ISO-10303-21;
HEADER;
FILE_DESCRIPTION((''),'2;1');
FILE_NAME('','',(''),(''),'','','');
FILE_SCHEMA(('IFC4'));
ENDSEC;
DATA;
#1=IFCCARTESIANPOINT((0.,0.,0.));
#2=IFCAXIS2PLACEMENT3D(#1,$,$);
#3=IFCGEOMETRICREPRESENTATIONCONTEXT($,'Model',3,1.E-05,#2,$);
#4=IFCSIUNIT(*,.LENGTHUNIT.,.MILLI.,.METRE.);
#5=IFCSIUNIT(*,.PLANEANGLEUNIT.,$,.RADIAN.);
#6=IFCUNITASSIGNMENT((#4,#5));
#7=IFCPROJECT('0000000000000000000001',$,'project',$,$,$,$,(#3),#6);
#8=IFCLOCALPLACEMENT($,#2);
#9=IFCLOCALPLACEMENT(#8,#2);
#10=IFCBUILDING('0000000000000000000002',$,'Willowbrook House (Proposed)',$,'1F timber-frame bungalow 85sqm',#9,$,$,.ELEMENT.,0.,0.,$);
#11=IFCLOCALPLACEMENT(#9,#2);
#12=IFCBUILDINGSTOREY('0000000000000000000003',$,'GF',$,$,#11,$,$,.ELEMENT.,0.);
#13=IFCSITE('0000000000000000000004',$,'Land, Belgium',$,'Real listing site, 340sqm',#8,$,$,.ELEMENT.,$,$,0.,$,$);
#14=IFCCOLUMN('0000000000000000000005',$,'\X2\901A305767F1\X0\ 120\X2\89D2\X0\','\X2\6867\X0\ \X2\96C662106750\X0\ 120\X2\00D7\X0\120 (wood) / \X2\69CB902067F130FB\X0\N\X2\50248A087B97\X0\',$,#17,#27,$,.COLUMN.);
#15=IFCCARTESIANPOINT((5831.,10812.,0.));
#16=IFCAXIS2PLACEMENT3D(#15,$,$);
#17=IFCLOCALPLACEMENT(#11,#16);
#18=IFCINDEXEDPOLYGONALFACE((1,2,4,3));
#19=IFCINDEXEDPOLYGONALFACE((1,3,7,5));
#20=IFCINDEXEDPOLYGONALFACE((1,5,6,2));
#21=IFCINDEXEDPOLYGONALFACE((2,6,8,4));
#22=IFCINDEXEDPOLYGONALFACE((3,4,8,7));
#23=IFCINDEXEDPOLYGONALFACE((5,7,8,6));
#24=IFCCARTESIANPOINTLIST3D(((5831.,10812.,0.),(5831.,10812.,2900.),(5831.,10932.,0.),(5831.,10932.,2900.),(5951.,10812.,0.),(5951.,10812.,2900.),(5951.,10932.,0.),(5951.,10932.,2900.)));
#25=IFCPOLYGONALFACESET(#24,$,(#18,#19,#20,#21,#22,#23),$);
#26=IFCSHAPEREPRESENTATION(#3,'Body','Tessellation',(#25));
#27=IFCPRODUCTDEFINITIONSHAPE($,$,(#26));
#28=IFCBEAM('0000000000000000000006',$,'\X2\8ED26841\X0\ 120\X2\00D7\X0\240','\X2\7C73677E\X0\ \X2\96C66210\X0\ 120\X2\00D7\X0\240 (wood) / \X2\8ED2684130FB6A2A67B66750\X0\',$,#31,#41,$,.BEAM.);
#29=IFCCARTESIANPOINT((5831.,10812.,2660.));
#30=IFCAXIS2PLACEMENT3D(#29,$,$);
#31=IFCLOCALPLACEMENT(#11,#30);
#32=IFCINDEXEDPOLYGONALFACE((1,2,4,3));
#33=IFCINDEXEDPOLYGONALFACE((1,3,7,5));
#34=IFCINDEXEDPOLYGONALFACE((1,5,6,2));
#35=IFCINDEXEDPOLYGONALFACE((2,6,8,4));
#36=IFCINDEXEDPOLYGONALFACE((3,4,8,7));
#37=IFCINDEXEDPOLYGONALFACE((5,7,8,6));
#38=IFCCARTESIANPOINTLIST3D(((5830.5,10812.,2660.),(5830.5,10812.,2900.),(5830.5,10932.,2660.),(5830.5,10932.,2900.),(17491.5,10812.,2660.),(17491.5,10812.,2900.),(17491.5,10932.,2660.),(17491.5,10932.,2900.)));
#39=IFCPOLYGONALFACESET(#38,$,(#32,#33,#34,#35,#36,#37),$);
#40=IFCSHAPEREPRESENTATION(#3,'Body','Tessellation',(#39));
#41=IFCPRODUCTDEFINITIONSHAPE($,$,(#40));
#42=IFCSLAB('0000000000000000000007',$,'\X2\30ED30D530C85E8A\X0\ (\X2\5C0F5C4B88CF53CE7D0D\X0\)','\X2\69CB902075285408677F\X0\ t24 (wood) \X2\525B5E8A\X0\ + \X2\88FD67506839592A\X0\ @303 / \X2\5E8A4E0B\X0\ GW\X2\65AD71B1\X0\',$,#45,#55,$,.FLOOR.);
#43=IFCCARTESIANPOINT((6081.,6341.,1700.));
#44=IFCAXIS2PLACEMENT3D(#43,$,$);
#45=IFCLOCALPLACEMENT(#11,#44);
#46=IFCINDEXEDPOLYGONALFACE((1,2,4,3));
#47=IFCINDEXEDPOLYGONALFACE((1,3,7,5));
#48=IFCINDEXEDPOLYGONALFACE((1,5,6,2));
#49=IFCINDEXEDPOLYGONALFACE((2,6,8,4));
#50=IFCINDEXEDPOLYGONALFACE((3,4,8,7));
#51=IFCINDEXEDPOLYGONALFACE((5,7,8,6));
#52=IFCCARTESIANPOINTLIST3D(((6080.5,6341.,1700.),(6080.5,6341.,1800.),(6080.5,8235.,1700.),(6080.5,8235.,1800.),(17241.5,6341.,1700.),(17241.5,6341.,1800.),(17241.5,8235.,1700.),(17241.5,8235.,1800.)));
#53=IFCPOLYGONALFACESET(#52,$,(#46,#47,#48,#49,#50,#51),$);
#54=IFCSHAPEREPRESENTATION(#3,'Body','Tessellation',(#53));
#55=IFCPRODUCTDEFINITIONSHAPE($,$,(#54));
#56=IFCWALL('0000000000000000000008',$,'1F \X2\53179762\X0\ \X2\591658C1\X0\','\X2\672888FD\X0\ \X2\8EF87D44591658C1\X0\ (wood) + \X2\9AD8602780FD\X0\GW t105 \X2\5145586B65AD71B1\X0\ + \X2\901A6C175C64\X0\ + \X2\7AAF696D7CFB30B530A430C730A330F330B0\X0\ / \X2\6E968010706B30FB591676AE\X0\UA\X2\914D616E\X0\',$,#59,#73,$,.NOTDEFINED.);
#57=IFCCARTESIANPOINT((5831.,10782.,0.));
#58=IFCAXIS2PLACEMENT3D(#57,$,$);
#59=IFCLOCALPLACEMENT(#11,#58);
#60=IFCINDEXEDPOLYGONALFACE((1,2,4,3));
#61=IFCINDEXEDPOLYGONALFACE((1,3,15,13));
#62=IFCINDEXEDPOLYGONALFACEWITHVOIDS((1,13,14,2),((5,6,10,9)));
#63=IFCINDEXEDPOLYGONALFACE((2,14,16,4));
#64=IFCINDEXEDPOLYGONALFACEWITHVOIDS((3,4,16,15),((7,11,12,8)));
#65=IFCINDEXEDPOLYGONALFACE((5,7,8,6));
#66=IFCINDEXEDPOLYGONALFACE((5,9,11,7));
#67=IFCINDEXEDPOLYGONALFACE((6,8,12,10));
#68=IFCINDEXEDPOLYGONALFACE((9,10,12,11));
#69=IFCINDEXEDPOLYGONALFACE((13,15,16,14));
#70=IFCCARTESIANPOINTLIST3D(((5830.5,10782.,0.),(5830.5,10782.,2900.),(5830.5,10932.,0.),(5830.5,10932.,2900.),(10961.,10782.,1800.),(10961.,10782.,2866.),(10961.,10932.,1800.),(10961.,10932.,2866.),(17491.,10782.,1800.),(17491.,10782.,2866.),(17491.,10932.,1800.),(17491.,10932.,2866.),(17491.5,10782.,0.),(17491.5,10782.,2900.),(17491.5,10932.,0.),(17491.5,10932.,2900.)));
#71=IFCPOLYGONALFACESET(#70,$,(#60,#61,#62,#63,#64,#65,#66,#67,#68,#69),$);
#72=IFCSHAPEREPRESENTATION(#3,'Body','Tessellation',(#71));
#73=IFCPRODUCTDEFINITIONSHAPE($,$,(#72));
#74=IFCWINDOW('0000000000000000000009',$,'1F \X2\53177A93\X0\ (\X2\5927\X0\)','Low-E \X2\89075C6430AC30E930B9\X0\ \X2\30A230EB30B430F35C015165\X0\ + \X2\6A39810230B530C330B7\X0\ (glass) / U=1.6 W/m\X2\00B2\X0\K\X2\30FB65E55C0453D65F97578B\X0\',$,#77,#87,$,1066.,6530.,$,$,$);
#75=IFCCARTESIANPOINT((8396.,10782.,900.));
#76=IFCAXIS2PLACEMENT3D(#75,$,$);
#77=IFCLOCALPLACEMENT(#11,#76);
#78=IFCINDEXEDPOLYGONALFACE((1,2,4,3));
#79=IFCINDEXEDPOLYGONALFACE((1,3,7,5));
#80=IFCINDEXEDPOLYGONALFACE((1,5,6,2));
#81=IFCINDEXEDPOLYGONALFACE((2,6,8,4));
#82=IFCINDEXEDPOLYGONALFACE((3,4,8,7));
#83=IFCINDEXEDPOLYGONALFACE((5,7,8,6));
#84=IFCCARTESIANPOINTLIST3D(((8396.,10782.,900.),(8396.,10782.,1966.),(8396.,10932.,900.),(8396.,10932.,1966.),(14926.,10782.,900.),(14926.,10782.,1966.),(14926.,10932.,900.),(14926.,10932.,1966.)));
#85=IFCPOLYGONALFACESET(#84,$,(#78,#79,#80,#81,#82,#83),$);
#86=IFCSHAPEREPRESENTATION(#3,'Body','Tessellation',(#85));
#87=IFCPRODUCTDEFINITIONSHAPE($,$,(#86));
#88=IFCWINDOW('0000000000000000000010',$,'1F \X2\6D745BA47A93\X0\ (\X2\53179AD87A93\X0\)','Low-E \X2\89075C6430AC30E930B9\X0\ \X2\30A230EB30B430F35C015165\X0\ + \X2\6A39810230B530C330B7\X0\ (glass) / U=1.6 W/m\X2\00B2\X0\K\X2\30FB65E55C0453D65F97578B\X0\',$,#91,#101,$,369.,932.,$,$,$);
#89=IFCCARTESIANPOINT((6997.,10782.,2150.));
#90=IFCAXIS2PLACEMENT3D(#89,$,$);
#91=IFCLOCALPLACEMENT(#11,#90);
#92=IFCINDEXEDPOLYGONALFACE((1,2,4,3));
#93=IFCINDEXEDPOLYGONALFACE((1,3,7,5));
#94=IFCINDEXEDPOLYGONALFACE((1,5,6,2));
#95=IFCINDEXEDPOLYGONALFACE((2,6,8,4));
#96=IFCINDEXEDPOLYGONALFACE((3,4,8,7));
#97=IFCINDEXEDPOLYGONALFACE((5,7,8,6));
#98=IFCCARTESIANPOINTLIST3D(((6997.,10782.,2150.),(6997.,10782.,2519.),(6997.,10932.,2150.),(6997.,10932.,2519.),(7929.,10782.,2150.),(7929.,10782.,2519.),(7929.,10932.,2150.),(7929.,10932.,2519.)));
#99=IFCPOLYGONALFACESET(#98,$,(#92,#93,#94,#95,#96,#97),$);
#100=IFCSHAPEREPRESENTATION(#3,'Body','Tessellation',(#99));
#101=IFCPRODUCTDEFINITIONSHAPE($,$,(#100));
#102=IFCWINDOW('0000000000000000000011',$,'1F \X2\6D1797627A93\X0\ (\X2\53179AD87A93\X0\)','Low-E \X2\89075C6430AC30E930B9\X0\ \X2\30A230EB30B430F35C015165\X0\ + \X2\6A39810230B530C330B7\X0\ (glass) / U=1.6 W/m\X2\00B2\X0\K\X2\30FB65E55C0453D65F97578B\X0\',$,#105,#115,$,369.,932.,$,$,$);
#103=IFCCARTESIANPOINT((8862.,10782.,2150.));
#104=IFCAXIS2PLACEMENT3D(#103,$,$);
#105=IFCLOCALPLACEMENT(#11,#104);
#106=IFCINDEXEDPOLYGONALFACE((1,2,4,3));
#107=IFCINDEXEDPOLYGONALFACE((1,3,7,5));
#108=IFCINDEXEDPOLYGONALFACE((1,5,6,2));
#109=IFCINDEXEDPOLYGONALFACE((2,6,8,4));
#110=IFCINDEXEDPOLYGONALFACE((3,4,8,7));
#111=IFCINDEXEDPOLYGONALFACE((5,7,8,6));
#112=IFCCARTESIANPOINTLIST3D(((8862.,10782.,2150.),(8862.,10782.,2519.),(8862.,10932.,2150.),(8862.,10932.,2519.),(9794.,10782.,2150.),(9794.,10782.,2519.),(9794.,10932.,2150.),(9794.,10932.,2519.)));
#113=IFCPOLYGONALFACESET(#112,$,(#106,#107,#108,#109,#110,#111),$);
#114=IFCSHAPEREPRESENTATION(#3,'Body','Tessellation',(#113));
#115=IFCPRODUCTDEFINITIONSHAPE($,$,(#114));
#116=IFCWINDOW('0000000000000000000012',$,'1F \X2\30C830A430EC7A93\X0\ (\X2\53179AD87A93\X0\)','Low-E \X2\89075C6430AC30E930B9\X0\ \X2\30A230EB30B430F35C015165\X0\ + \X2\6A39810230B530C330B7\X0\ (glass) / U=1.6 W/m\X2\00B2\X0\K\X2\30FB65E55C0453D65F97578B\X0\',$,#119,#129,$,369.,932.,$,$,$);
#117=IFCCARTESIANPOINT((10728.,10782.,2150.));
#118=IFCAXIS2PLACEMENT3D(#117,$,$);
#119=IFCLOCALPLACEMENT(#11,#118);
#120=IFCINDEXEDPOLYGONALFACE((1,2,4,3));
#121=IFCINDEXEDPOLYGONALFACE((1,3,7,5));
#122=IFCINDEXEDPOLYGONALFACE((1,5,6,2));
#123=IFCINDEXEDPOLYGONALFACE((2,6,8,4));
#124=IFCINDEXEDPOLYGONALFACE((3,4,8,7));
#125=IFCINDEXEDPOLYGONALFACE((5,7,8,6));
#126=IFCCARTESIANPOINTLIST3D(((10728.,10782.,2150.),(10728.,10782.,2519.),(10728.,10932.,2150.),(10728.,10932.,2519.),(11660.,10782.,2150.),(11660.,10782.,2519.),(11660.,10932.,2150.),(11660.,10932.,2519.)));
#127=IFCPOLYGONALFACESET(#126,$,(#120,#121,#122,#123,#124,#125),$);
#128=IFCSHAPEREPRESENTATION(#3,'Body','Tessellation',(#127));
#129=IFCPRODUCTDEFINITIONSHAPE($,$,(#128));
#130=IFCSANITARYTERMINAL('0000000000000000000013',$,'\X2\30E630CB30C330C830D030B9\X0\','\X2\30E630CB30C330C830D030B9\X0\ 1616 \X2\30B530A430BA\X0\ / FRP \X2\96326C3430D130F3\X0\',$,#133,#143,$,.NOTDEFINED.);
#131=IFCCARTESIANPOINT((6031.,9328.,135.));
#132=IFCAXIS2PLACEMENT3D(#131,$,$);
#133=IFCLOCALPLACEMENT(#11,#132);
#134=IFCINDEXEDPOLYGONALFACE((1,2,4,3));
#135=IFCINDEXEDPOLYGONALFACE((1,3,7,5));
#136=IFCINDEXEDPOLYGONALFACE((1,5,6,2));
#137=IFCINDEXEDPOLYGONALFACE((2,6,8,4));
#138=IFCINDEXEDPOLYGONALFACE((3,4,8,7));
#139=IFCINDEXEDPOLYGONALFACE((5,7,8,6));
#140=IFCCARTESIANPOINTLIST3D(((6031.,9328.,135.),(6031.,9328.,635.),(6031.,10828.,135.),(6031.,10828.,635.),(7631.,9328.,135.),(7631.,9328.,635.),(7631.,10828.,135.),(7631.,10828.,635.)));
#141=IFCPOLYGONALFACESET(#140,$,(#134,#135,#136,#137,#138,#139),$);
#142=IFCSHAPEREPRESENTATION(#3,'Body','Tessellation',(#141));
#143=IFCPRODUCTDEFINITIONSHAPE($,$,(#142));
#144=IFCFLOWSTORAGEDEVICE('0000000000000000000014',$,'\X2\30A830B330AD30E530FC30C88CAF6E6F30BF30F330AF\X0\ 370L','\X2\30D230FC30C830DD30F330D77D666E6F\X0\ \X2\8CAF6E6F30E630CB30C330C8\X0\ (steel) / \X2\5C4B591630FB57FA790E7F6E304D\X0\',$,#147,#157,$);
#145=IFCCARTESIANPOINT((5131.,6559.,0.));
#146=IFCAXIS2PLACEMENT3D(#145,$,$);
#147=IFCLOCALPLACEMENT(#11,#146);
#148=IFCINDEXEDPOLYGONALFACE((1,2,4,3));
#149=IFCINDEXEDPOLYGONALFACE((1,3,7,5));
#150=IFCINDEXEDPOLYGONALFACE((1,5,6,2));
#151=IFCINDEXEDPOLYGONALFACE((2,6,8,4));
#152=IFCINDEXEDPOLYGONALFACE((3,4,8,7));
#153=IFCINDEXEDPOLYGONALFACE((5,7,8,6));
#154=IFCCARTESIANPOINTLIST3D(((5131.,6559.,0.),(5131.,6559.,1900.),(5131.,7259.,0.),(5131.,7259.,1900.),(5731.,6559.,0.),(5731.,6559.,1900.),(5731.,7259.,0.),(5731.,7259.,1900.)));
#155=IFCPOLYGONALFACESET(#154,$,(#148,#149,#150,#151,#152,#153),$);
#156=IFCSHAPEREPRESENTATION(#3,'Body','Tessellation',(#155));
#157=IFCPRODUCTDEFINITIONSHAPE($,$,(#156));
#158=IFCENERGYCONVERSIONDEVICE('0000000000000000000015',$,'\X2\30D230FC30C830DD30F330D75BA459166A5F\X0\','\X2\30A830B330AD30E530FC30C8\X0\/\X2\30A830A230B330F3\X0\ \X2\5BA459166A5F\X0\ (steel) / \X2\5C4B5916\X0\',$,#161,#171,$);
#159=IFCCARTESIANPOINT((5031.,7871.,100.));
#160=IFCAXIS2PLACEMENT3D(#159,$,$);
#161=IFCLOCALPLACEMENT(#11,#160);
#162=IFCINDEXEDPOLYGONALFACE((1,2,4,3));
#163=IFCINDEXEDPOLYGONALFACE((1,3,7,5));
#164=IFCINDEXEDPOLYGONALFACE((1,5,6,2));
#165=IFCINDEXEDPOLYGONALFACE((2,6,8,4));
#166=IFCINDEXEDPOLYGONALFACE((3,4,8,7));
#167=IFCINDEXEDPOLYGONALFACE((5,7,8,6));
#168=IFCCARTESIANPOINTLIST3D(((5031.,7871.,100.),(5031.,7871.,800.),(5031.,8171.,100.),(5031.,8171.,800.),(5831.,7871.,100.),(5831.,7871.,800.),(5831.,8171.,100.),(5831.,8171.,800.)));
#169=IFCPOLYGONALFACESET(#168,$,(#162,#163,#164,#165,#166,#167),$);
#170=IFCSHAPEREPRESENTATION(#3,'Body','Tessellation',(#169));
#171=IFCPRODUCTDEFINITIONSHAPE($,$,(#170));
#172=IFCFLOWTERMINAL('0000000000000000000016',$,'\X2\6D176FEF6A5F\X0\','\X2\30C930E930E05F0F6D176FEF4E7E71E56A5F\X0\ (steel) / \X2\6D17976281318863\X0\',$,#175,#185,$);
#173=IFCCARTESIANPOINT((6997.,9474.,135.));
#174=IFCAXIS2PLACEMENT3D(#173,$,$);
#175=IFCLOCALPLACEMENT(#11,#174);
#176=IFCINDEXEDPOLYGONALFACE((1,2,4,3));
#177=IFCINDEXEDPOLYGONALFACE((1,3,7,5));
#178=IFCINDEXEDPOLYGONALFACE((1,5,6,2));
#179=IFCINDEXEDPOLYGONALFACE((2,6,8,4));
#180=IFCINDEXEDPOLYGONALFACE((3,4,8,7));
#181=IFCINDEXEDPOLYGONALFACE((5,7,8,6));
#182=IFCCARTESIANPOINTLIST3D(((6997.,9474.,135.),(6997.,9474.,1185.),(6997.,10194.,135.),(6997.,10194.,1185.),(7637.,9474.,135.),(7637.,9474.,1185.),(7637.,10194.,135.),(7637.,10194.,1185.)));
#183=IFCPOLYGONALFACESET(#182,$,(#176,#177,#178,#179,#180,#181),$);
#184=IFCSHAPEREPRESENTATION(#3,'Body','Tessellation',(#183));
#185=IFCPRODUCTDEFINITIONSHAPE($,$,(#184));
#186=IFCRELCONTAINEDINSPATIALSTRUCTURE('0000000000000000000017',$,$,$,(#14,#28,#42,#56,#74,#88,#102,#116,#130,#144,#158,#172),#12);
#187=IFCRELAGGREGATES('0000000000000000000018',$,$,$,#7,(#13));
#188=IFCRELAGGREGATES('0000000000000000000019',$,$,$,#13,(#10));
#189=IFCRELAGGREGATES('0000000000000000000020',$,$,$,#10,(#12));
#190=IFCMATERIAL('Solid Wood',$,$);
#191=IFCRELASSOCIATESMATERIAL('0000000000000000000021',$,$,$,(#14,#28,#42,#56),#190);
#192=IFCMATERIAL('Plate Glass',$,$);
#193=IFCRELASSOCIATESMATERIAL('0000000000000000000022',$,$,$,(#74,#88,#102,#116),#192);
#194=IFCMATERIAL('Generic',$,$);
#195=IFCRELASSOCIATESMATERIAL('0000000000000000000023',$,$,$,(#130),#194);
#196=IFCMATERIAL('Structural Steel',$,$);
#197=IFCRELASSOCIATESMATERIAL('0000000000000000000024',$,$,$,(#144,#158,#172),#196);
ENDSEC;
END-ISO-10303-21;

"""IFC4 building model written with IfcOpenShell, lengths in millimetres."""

from ifc_helpers import new_model, si_unit, frame, frame_2d, origin, place, context, project, spatial, rectangle, extrude, material, element, fill, save


model = new_model("IFC4")

# Units and contexts
model_context = context("Model", 3, precision=1e-05, world=origin())
ifc_project = project(units=[si_unit("LENGTHUNIT", "METRE", prefix="MILLI"), si_unit("PLANEANGLEUNIT", "RADIAN")], contexts=[model_context])

# Site, building, storey
site_placement = place(None, origin())
site = spatial("IfcSite", under=ifc_project, at=site_placement, Name="Land, Belgium", ObjectType="Real listing site, 340sqm", CompositionType="ELEMENT", RefElevation=0.0)
building_placement = place(site_placement, origin())
building = spatial("IfcBuilding", under=site, at=building_placement, Name="Willowbrook House (Proposed)", ObjectType="1F timber-frame bungalow 85sqm", CompositionType="ELEMENT", ElevationOfRefHeight=0.0, ElevationOfTerrain=0.0)
storey_placement = place(building_placement, origin())
storey = spatial("IfcBuildingStorey", under=building, at=storey_placement, Name="GF", CompositionType="ELEMENT", Elevation=0.0)

# Column
ifc_material_1 = material(Name="Solid Wood")
column_1_placement = place(storey_placement, frame((5831.0, 10812.0, 0.0)))
element("IfcColumn", 1, at=column_1_placement, inside=storey, material=ifc_material_1, Name="通し柱 120角", Description="桧 集成材 120×120 (wood) / 構造柱・N値計算", PredefinedType="COLUMN", context=model_context, shape_type="SweptSolid", body=[
    extrude(rectangle(XDim=120.0, YDim=120.0, at=frame_2d((60.0, 60.0))), frame((5831.0, 10812.0, 0.0)), (0.0, 0.0, 1.0), 2900.0),
])

# Beam
beam_1_placement = place(storey_placement, frame((5831.0, 10812.0, 2660.0)))
element("IfcBeam", 2, at=beam_1_placement, inside=storey, material=ifc_material_1, Name="軒桁 120×240", Description="米松 集成 120×240 (wood) / 軒桁・横架材", PredefinedType="BEAM", context=model_context, shape_type="SweptSolid", body=[
    extrude(rectangle(XDim=11661.0, YDim=120.0, at=frame_2d((5830.0, 60.0))), frame((5831.0, 10812.0, 2660.0)), (0.0, 0.0, 1.0), 240.0),
])

# Slab
slab_placement = place(storey_placement, frame((6081.0, 6341.0, 1700.0)))
element("IfcSlab", 3, at=slab_placement, inside=storey, material=ifc_material_1, Name="ロフト床 (小屋裏収納)", Description="構造用合板 t24 (wood) 剛床 + 製材根太 @303 / 床下 GW断熱", PredefinedType="FLOOR", context=model_context, shape_type="SweptSolid", body=[
    extrude(rectangle(XDim=11161.0, YDim=1894.0, at=frame_2d((5580.0, 947.0))), frame((6081.0, 6341.0, 1700.0)), (0.0, 0.0, 1.0), 100.0),
])

# Wall, openings, windows
wall_1_placement = place(storey_placement, frame((5831.0, 10782.0, 0.0)))
wall_1 = element("IfcWall", 4, at=wall_1_placement, inside=storey, material=ifc_material_1, Name="1F 北面 外壁", Description="木製 軸組外壁 (wood) + 高性能GW t105 充填断熱 + 通気層 + 窯業系サイディング / 準耐火・外皮UA配慮", PredefinedType="NOTDEFINED", context=model_context, shape_type="SweptSolid", body=[
    extrude(rectangle(XDim=11661.0, YDim=150.0, at=frame_2d((5830.0, 75.0))), frame((5831.0, 10782.0, 0.0)), (0.0, 0.0, 1.0), 2900.0),
])
opening_1_placement = place(storey_placement, frame((8396.0, 10782.0, 900.0)))
opening_1 = element("IfcOpeningElement", 5, at=opening_1_placement, cuts=wall_1, PredefinedType="NOTDEFINED", context=model_context, shape_type="SweptSolid", body=[
    extrude(rectangle(XDim=6530.0, YDim=150.0, at=frame_2d((3265.0, 75.0))), frame((8396.0, 10782.0, 900.0)), (0.0, 0.0, 1.0), 1066.0),
])
opening_2_placement = place(storey_placement, frame((6997.0, 10782.0, 2150.0)))
opening_2 = element("IfcOpeningElement", 6, at=opening_2_placement, cuts=wall_1, PredefinedType="NOTDEFINED", context=model_context, shape_type="SweptSolid", body=[
    extrude(rectangle(XDim=932.0, YDim=150.0, at=frame_2d((466.0, 75.0))), frame((6997.0, 10782.0, 2150.0)), (0.0, 0.0, 1.0), 369.0),
])
opening_3_placement = place(storey_placement, frame((8862.0, 10782.0, 2150.0)))
opening_3 = element("IfcOpeningElement", 7, at=opening_3_placement, cuts=wall_1, PredefinedType="NOTDEFINED", context=model_context, shape_type="SweptSolid", body=[
    extrude(rectangle(XDim=932.0, YDim=150.0, at=frame_2d((466.0, 75.0))), frame((8862.0, 10782.0, 2150.0)), (0.0, 0.0, 1.0), 369.0),
])
opening_4_placement = place(storey_placement, frame((10728.0, 10782.0, 2150.0)))
opening_4 = element("IfcOpeningElement", 8, at=opening_4_placement, cuts=wall_1, PredefinedType="NOTDEFINED", context=model_context, shape_type="SweptSolid", body=[
    extrude(rectangle(XDim=932.0, YDim=150.0, at=frame_2d((466.0, 75.0))), frame((10728.0, 10782.0, 2150.0)), (0.0, 0.0, 1.0), 369.0),
])
ifc_material_2 = material(Name="Plate Glass")
window_1_placement = place(storey_placement, frame((8396.0, 10782.0, 900.0)))
window_1 = element("IfcWindow", 9, at=window_1_placement, inside=storey, material=ifc_material_2, Name="1F 北窓 (大)", Description="Low-E 複層ガラス アルゴン封入 + 樹脂サッシ (glass) / U=1.6 W/m²K・日射取得型", OverallHeight=1066.0, OverallWidth=6530.0, context=model_context, shape_type="SweptSolid", body=[
    extrude(rectangle(XDim=6530.0, YDim=150.0, at=frame_2d((3265.0, 75.0))), frame((8396.0, 10782.0, 900.0)), (0.0, 0.0, 1.0), 1066.0),
])
fill(opening_1, window_1)
window_2_placement = place(storey_placement, frame((6997.0, 10782.0, 2150.0)))
window_2 = element("IfcWindow", 10, at=window_2_placement, inside=storey, material=ifc_material_2, Name="1F 浴室窓 (北高窓)", Description="Low-E 複層ガラス アルゴン封入 + 樹脂サッシ (glass) / U=1.6 W/m²K・日射取得型", OverallHeight=369.0, OverallWidth=932.0, context=model_context, shape_type="SweptSolid", body=[
    extrude(rectangle(XDim=932.0, YDim=150.0, at=frame_2d((466.0, 75.0))), frame((6997.0, 10782.0, 2150.0)), (0.0, 0.0, 1.0), 369.0),
])
fill(opening_2, window_2)
window_3_placement = place(storey_placement, frame((8862.0, 10782.0, 2150.0)))
window_3 = element("IfcWindow", 11, at=window_3_placement, inside=storey, material=ifc_material_2, Name="1F 洗面窓 (北高窓)", Description="Low-E 複層ガラス アルゴン封入 + 樹脂サッシ (glass) / U=1.6 W/m²K・日射取得型", OverallHeight=369.0, OverallWidth=932.0, context=model_context, shape_type="SweptSolid", body=[
    extrude(rectangle(XDim=932.0, YDim=150.0, at=frame_2d((466.0, 75.0))), frame((8862.0, 10782.0, 2150.0)), (0.0, 0.0, 1.0), 369.0),
])
fill(opening_3, window_3)
window_4_placement = place(storey_placement, frame((10728.0, 10782.0, 2150.0)))
window_4 = element("IfcWindow", 12, at=window_4_placement, inside=storey, material=ifc_material_2, Name="1F トイレ窓 (北高窓)", Description="Low-E 複層ガラス アルゴン封入 + 樹脂サッシ (glass) / U=1.6 W/m²K・日射取得型", OverallHeight=369.0, OverallWidth=932.0, context=model_context, shape_type="SweptSolid", body=[
    extrude(rectangle(XDim=932.0, YDim=150.0, at=frame_2d((466.0, 75.0))), frame((10728.0, 10782.0, 2150.0)), (0.0, 0.0, 1.0), 369.0),
])
fill(opening_4, window_4)

# Sanitary terminal
ifc_material_3 = material(Name="Generic")
sanitary_terminal_placement = place(storey_placement, frame((6031.0, 9328.0, 135.0)))
element("IfcSanitaryTerminal", 13, at=sanitary_terminal_placement, inside=storey, material=ifc_material_3, Name="ユニットバス", Description="ユニットバス 1616 サイズ / FRP 防水パン", PredefinedType="NOTDEFINED", context=model_context, shape_type="SweptSolid", body=[
    extrude(rectangle(XDim=1600.0, YDim=1500.0, at=frame_2d((800.0, 750.0))), frame((6031.0, 9328.0, 135.0)), (0.0, 0.0, 1.0), 500.0),
])

# Flow storage device
ifc_material_4 = material(Name="Structural Steel")
flow_storage_device_placement = place(storey_placement, frame((5131.0, 6559.0, 0.0)))
element("IfcFlowStorageDevice", 14, at=flow_storage_device_placement, inside=storey, material=ifc_material_4, Name="エコキュート貯湯タンク 370L", Description="ヒートポンプ給湯 貯湯ユニット (steel) / 屋外・基礎置き", context=model_context, shape_type="SweptSolid", body=[
    extrude(rectangle(XDim=600.0, YDim=700.0, at=frame_2d((300.0, 350.0))), frame((5131.0, 6559.0, 0.0)), (0.0, 0.0, 1.0), 1900.0),
])

# Energy conversion device
energy_conversion_device_placement = place(storey_placement, frame((5031.0, 7871.0, 100.0)))
element("IfcEnergyConversionDevice", 15, at=energy_conversion_device_placement, inside=storey, material=ifc_material_4, Name="ヒートポンプ室外機", Description="エコキュート/エアコン 室外機 (steel) / 屋外", context=model_context, shape_type="SweptSolid", body=[
    extrude(rectangle(XDim=800.0, YDim=300.0, at=frame_2d((400.0, 150.0))), frame((5031.0, 7871.0, 100.0)), (0.0, 0.0, 1.0), 700.0),
])

# Flow terminal
flow_terminal_placement = place(storey_placement, frame((6997.0, 9474.0, 135.0)))
element("IfcFlowTerminal", 16, at=flow_terminal_placement, inside=storey, material=ifc_material_4, Name="洗濯機", Description="ドラム式洗濯乾燥機 (steel) / 洗面脱衣", context=model_context, shape_type="SweptSolid", body=[
    extrude(rectangle(XDim=640.0, YDim=720.0, at=frame_2d((320.0, 360.0))), frame((6997.0, 9474.0, 135.0)), (0.0, 0.0, 1.0), 1050.0),
])

save(model, "model.ifc")
